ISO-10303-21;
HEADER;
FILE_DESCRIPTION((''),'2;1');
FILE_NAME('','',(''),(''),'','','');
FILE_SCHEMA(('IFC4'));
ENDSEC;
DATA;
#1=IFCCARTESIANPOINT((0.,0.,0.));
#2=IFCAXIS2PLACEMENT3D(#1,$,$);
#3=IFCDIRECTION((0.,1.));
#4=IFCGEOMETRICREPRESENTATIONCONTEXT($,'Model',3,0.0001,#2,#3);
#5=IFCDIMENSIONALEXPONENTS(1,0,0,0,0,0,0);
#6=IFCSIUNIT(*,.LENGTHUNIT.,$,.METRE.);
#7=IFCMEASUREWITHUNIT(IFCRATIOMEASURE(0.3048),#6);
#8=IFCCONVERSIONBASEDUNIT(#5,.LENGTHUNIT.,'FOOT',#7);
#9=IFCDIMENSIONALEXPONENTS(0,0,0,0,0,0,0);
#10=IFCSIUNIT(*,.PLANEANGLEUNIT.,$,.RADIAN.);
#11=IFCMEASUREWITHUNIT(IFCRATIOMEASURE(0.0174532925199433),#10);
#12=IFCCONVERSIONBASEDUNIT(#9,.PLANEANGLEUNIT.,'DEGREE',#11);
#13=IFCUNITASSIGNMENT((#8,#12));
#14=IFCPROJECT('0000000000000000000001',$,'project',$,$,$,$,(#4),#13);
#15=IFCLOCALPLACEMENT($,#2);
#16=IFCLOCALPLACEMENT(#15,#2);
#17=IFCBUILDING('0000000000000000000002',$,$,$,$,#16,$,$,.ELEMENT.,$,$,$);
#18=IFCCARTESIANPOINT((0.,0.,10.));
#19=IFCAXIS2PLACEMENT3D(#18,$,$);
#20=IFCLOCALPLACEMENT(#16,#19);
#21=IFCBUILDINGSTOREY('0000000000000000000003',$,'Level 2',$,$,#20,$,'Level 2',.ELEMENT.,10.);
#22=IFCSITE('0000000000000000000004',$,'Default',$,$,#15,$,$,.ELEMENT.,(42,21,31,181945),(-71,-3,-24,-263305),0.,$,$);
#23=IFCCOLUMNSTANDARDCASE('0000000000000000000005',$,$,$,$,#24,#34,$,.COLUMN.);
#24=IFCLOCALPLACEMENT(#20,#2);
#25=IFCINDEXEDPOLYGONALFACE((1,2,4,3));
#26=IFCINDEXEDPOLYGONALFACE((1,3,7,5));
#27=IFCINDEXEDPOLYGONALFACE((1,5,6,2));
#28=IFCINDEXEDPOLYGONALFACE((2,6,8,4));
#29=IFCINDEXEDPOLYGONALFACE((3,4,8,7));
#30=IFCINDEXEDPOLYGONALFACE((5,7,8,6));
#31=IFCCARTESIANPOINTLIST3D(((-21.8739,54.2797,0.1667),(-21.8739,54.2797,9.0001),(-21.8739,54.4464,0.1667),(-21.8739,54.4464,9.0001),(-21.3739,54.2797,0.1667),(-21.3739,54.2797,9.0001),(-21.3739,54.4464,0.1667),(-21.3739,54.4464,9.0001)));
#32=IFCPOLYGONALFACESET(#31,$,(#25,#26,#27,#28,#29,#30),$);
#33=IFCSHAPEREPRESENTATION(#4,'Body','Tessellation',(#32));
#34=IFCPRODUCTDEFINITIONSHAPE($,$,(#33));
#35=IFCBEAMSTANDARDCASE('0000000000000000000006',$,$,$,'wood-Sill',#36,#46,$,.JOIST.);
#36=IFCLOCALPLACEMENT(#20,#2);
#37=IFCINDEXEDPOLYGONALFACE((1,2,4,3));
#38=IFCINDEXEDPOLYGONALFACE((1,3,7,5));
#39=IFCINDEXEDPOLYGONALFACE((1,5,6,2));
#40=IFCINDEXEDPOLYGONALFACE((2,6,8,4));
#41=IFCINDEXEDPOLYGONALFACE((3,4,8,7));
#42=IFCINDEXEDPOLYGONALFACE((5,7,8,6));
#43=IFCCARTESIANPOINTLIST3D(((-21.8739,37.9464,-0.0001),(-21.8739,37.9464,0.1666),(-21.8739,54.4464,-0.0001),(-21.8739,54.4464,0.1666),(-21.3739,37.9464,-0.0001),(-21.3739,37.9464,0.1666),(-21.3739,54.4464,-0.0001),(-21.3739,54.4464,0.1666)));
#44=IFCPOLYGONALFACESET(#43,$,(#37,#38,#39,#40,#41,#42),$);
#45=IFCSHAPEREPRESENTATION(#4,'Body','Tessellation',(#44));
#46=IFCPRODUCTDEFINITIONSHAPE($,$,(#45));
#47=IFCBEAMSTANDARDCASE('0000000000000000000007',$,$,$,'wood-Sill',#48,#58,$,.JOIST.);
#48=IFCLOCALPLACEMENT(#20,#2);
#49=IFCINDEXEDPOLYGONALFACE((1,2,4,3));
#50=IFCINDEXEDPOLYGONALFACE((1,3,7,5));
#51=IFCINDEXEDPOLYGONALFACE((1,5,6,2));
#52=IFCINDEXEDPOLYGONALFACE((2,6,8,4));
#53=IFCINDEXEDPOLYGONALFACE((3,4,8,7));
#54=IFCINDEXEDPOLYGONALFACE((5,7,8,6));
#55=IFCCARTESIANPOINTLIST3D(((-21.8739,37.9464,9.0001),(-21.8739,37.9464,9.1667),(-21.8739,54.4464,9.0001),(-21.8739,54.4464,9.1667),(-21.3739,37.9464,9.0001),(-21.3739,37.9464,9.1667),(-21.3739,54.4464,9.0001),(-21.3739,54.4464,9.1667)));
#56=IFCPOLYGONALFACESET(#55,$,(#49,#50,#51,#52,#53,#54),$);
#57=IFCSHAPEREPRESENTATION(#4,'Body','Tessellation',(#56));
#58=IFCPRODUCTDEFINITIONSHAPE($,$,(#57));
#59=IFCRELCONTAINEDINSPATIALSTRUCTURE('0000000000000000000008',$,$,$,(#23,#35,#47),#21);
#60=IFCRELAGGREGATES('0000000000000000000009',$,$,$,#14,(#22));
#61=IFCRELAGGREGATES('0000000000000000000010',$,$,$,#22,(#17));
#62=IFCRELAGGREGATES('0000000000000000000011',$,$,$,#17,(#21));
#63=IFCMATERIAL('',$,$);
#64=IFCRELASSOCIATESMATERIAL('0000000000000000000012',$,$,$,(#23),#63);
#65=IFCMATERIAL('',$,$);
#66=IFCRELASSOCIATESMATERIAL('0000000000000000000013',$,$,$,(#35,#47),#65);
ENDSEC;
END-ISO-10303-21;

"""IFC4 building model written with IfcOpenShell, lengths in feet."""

from ifc_helpers import new_model, entity, si_unit, converted_unit, direction, frame, origin, origin_with_axes, place, context, project, spatial, rectangle, extrude, material, element, save


model = new_model("IFC4")

# Units and contexts
model_context = context("Model", 3, precision=0.0001, world=origin(), true_north=direction((0.0, 1.0)))
ifc_project = project(units=[converted_unit("LENGTHUNIT", "FOOT", entity("IfcRatioMeasure", 0.3048), si_unit("LENGTHUNIT", "METRE"), dimensions=[1, 0, 0, 0, 0, 0, 0]), converted_unit("PLANEANGLEUNIT", "DEGREE", entity("IfcRatioMeasure", 0.0174532925199433), si_unit("PLANEANGLEUNIT", "RADIAN"), dimensions=[0, 0, 0, 0, 0, 0, 0])], contexts=[model_context])

# Site, building, storey
site_placement = place(None, origin())
site = spatial("IfcSite", under=ifc_project, at=site_placement, Name="Default", CompositionType="ELEMENT", RefLatitude=(42, 21, 31, 181945), RefLongitude=(-71, -3, -24, -263305), RefElevation=0.0)
building_placement = place(site_placement, origin())
building = spatial("IfcBuilding", under=site, at=building_placement, CompositionType="ELEMENT")
storey_placement = place(building_placement, frame((0.0, 0.0, 10.0)))
storey = spatial("IfcBuildingStorey", under=building, at=storey_placement, Name="Level 2", LongName="Level 2", CompositionType="ELEMENT", Elevation=10.0)

# Column
ifc_material_1 = material(Name="")
placement_1 = place(storey_placement, frame((-21.6239, 54.4464, 0.0), z_axis=(0.0, 0.0, 1.0), x_axis=(0.0, -1.0, 0.0)))
for number, where, z_axis, x_axis in (
    (1, (0.0833, 0.0, 0.1667), (0.0, 0.0, 1.0), (1.0, 0.0, 0.0)),
):
    element("IfcColumnStandardCase", number, at=place(placement_1, frame(where, z_axis=z_axis, x_axis=x_axis)), inside=storey, material=ifc_material_1, PredefinedType="COLUMN", context=model_context, shape_type="SweptSolid", body=[
        extrude(rectangle(XDim=0.1667, YDim=0.5), origin(), (0.0, 0.0, 1.0), 8.8334),
    ])

# Beams
ifc_material_2 = material(Name="")
for number, where, z_axis, x_axis in (
    (2, (0.0, 0.0, 0.0833), (1.0, 0.0, 0.0), (0.0, 0.0, 1.0)),
    (3, (0.0, 0.0, 9.0834), (1.0, 0.0, 0.0), (0.0, 0.0, 1.0)),
):
    element("IfcBeamStandardCase", number, at=place(placement_1, frame(where, z_axis=z_axis, x_axis=x_axis)), inside=storey, material=ifc_material_2, ObjectType="wood-Sill", PredefinedType="JOIST", context=model_context, shape_type="SweptSolid", body=[
        extrude(rectangle(XDim=0.1667, YDim=0.5), origin_with_axes(), (0.0, 0.0, 1.0), 16.5),
    ])

save(model, "model.ifc")
